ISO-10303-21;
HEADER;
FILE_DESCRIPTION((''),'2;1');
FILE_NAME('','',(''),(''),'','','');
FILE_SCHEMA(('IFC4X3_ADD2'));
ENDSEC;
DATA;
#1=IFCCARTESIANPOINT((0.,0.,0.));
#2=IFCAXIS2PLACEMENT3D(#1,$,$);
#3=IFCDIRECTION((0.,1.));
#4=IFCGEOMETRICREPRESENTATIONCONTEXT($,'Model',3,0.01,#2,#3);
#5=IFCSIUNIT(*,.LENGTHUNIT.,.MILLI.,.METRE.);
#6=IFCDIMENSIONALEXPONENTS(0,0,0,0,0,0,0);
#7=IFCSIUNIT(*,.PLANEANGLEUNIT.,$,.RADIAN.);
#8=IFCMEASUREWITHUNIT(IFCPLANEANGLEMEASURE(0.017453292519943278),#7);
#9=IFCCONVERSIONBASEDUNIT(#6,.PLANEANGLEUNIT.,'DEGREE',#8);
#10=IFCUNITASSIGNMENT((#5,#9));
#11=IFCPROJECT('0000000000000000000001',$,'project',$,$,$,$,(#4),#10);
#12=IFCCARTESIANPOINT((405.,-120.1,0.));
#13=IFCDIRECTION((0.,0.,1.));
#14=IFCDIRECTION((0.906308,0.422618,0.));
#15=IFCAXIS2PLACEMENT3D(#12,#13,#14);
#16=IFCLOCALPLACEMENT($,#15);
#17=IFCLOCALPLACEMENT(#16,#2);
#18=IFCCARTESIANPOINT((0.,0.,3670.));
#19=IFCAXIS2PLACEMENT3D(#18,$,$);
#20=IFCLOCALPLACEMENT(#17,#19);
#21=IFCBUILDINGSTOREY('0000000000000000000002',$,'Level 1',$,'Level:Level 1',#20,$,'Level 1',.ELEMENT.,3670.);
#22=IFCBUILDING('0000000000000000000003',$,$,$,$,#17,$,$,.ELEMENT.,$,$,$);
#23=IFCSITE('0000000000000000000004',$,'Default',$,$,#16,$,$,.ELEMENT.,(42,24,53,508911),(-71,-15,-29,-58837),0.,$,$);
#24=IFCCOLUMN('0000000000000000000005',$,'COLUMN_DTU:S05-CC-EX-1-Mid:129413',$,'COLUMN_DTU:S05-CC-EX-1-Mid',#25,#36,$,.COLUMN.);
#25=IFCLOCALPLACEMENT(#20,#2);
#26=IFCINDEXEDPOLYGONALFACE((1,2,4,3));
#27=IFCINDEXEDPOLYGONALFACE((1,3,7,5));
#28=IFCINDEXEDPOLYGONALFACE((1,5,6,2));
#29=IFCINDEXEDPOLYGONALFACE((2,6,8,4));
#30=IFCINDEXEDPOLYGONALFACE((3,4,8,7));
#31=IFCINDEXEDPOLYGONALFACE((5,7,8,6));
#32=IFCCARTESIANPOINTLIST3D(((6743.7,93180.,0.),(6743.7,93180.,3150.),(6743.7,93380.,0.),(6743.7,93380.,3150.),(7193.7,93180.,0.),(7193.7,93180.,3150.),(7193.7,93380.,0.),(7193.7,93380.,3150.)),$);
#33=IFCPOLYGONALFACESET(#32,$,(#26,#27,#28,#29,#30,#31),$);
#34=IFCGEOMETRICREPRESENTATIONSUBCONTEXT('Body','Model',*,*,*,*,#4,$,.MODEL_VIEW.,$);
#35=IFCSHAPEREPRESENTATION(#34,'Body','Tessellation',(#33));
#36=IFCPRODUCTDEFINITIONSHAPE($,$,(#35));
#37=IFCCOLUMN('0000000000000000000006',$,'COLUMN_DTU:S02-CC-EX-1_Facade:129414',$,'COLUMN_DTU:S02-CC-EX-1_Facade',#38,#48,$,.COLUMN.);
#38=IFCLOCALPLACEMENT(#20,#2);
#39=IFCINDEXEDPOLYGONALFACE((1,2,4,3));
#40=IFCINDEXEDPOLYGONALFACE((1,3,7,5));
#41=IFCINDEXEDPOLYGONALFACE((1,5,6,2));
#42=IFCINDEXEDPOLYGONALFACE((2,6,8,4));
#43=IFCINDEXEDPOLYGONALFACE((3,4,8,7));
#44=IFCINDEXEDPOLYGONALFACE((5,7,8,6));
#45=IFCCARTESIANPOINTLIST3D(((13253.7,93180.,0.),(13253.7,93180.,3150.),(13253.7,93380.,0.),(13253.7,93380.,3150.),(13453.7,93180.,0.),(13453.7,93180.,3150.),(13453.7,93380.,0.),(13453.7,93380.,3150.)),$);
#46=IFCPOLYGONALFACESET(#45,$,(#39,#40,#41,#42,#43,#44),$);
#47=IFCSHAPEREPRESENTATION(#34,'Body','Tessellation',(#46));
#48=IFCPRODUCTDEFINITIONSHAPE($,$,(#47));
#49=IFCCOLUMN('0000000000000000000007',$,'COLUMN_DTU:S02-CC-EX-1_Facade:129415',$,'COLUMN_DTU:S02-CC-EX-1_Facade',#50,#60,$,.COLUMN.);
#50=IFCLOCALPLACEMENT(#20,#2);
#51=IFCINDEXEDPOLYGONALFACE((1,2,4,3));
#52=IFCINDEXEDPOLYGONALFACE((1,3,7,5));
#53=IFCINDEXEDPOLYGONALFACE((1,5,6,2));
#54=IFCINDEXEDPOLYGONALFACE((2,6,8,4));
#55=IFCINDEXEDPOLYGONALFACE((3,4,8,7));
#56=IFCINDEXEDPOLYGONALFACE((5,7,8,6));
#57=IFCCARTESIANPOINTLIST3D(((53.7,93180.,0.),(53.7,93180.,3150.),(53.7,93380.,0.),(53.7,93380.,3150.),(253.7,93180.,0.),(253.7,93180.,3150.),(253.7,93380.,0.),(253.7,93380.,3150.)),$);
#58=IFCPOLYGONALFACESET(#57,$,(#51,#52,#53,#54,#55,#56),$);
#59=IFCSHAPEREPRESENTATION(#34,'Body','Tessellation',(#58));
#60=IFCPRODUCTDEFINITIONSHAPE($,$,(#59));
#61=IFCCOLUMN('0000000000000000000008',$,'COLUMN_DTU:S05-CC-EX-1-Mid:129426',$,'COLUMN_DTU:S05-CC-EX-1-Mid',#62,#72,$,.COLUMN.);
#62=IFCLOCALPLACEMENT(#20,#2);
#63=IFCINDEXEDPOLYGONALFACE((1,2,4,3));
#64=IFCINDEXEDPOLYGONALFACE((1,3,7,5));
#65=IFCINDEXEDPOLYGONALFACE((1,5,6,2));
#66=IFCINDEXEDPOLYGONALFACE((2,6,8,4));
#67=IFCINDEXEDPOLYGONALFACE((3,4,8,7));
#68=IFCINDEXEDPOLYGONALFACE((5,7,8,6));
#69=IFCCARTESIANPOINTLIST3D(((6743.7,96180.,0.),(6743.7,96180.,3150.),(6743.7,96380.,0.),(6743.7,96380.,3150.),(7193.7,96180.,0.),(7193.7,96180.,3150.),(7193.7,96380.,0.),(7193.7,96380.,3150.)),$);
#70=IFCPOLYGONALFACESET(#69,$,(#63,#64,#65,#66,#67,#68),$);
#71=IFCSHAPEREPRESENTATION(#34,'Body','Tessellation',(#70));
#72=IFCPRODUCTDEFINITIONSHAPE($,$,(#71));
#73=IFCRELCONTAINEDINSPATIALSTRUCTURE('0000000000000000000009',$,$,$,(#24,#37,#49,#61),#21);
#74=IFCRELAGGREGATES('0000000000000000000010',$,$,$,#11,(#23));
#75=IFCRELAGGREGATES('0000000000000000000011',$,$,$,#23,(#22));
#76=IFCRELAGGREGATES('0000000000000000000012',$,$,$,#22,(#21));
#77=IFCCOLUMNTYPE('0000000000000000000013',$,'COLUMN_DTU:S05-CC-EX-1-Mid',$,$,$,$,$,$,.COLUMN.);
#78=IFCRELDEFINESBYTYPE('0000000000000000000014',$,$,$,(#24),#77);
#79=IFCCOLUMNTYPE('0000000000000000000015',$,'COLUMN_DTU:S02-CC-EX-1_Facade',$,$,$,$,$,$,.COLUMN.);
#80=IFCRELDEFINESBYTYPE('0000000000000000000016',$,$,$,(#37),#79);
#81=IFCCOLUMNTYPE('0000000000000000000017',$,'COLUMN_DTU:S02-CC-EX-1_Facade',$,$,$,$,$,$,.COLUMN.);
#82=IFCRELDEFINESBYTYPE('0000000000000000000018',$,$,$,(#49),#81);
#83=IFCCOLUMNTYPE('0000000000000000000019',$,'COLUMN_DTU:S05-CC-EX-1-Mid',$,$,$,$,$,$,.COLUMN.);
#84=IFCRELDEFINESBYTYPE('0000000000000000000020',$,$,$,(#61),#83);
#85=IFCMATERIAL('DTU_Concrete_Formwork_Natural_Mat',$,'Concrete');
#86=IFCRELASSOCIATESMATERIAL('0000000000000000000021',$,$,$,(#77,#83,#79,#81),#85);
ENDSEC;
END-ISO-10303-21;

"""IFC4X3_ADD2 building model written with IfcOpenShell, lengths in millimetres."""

from ifc_helpers import new_model, entity, si_unit, converted_unit, direction, frame, frame_2d, origin, origin_2d_with_axis, place, context, subcontext, project, spatial, rectangle, extrude, source, transform, mapped, material, material_profile, profile_set, type_object, type_shapes, element, save


model = new_model("IFC4X3_ADD2")

# Units and contexts
model_context = context("Model", 3, precision=0.01, world=origin(), true_north=direction((0.0, 1.0)))
body_context = subcontext(model_context, "Body", "Model", "MODEL_VIEW")
ifc_project = project(units=[si_unit("LENGTHUNIT", "METRE", prefix="MILLI"), converted_unit("PLANEANGLEUNIT", "DEGREE", entity("IfcPlaneAngleMeasure", 0.017453292519943278), si_unit("PLANEANGLEUNIT", "RADIAN"), dimensions=[0, 0, 0, 0, 0, 0, 0])], contexts=[model_context])

# Site, building, storey
site_placement = place(None, frame((405.0, -120.1, 0.0), z_axis=(0.0, 0.0, 1.0), x_axis=(0.906308, 0.422618, 0.0)))
site = spatial("IfcSite", under=ifc_project, at=site_placement, Name="Default", CompositionType="ELEMENT", RefLatitude=(42, 24, 53, 508911), RefLongitude=(-71, -15, -29, -58837), RefElevation=0.0)
building_placement = place(site_placement, origin())
building = spatial("IfcBuilding", under=site, at=building_placement, CompositionType="ELEMENT")
storey_placement = place(building_placement, frame((0.0, 0.0, 3670.0)))
storey = spatial("IfcBuildingStorey", under=building, at=storey_placement, Name="Level 1", ObjectType="Level:Level 1", LongName="Level 1", CompositionType="ELEMENT", Elevation=3670.0)

# Columns
ifc_material = material(Name="DTU_Concrete_Formwork_Natural_Mat", Category="Concrete")
ifc_material_profile_1 = material_profile(ifc_material, rectangle(XDim=200.0, YDim=450.0, at=origin_2d_with_axis()), Name="S05-CC-EX-1-Mid")
ifc_profile_set_1 = profile_set([ifc_material_profile_1], Name="S05-CC-EX-1-Mid")
ifc_material_profile_2 = material_profile(ifc_material, rectangle(XDim=200.0, YDim=200.0, at=frame_2d((0.0, 0.0), x_axis=(1.0, 0.0))), Name="S02-CC-EX-1_Facade")
ifc_profile_set_2 = profile_set([ifc_material_profile_2], Name="S02-CC-EX-1_Facade")
column_type_1 = type_object("IfcColumnType", Name="COLUMN_DTU:S05-CC-EX-1-Mid", PredefinedType="COLUMN", material=ifc_profile_set_1)
shared_shape_1 = source(origin(), body_context, "Body", "SweptSolid", [
    extrude(rectangle(XDim=200.0, YDim=450.0, at=frame_2d((0.0, 0.0), x_axis=(1.0, 0.0))), frame((6968.7, 93280.0, 3670.0), z_axis=(0.0, 0.0, 1.0), x_axis=(0.0, 1.0, 0.0)), (0.0, 0.0, 1.0), 3150.0),
])
type_shapes(column_type_1, [shared_shape_1])
column_1_placement = place(storey_placement, frame((0.0, 0.0, -3670.0)))
element("IfcColumn", 1, at=column_1_placement, inside=storey, type_object=column_type_1, Name="COLUMN_DTU:S05-CC-EX-1-Mid:129413", ObjectType="COLUMN_DTU:S05-CC-EX-1-Mid", PredefinedType="COLUMN", context=body_context, shape_type="MappedRepresentation", body=[
    mapped(shared_shape_1, transform((0.0, 0.0, 0.0), scale=1.0)),
])
column_type_2 = type_object("IfcColumnType", Name="COLUMN_DTU:S02-CC-EX-1_Facade", PredefinedType="COLUMN", material=ifc_profile_set_2)
shared_shape_2 = source(origin(), body_context, "Body", "SweptSolid", [
    extrude(rectangle(XDim=200.0, YDim=200.0, at=frame_2d((0.0, 0.0), x_axis=(1.0, 0.0))), frame((13353.7, 93280.0, 3670.0), z_axis=(0.0, 0.0, 1.0), x_axis=(0.0, -1.0, 0.0)), (0.0, 0.0, 1.0), 3150.0),
])
type_shapes(column_type_2, [shared_shape_2])
column_2_placement = place(storey_placement, frame((0.0, 0.0, -3670.0)))
element("IfcColumn", 2, at=column_2_placement, inside=storey, type_object=column_type_2, Name="COLUMN_DTU:S02-CC-EX-1_Facade:129414", ObjectType="COLUMN_DTU:S02-CC-EX-1_Facade", PredefinedType="COLUMN", context=body_context, shape_type="MappedRepresentation", body=[
    mapped(shared_shape_2, transform((0.0, 0.0, 0.0), scale=1.0)),
])
column_type_3 = type_object("IfcColumnType", Name="COLUMN_DTU:S02-CC-EX-1_Facade", PredefinedType="COLUMN", material=ifc_profile_set_2)
shared_shape_3 = source(origin(), body_context, "Body", "SweptSolid", [
    extrude(rectangle(XDim=200.0, YDim=200.0, at=frame_2d((0.0, 0.0), x_axis=(1.0, 0.0))), frame((153.7, 93280.0, 3670.0), z_axis=(0.0, 0.0, 1.0), x_axis=(0.0, -1.0, 0.0)), (0.0, 0.0, 1.0), 3150.0),
])
type_shapes(column_type_3, [shared_shape_3])
column_3_placement = place(storey_placement, frame((0.0, 0.0, -3670.0)))
element("IfcColumn", 3, at=column_3_placement, inside=storey, type_object=column_type_3, Name="COLUMN_DTU:S02-CC-EX-1_Facade:129415", ObjectType="COLUMN_DTU:S02-CC-EX-1_Facade", PredefinedType="COLUMN", context=body_context, shape_type="MappedRepresentation", body=[
    mapped(shared_shape_3, transform((0.0, 0.0, 0.0), scale=1.0)),
])
column_type_4 = type_object("IfcColumnType", Name="COLUMN_DTU:S05-CC-EX-1-Mid", PredefinedType="COLUMN", material=ifc_profile_set_1)
shared_shape_4 = source(origin(), body_context, "Body", "SweptSolid", [
    extrude(rectangle(XDim=200.0, YDim=450.0, at=frame_2d((0.0, 0.0), x_axis=(1.0, 0.0))), frame((6968.7, 96280.0, 3670.0), z_axis=(0.0, 0.0, 1.0), x_axis=(0.0, 1.0, 0.0)), (0.0, 0.0, 1.0), 3150.0),
])
type_shapes(column_type_4, [shared_shape_4])
column_4_placement = place(storey_placement, frame((0.0, 0.0, -3670.0)))
element("IfcColumn", 4, at=column_4_placement, inside=storey, type_object=column_type_4, Name="COLUMN_DTU:S05-CC-EX-1-Mid:129426", ObjectType="COLUMN_DTU:S05-CC-EX-1-Mid", PredefinedType="COLUMN", context=body_context, shape_type="MappedRepresentation", body=[
    mapped(shared_shape_4, transform((0.0, 0.0, 0.0), scale=1.0)),
])

save(model, "model.ifc")
